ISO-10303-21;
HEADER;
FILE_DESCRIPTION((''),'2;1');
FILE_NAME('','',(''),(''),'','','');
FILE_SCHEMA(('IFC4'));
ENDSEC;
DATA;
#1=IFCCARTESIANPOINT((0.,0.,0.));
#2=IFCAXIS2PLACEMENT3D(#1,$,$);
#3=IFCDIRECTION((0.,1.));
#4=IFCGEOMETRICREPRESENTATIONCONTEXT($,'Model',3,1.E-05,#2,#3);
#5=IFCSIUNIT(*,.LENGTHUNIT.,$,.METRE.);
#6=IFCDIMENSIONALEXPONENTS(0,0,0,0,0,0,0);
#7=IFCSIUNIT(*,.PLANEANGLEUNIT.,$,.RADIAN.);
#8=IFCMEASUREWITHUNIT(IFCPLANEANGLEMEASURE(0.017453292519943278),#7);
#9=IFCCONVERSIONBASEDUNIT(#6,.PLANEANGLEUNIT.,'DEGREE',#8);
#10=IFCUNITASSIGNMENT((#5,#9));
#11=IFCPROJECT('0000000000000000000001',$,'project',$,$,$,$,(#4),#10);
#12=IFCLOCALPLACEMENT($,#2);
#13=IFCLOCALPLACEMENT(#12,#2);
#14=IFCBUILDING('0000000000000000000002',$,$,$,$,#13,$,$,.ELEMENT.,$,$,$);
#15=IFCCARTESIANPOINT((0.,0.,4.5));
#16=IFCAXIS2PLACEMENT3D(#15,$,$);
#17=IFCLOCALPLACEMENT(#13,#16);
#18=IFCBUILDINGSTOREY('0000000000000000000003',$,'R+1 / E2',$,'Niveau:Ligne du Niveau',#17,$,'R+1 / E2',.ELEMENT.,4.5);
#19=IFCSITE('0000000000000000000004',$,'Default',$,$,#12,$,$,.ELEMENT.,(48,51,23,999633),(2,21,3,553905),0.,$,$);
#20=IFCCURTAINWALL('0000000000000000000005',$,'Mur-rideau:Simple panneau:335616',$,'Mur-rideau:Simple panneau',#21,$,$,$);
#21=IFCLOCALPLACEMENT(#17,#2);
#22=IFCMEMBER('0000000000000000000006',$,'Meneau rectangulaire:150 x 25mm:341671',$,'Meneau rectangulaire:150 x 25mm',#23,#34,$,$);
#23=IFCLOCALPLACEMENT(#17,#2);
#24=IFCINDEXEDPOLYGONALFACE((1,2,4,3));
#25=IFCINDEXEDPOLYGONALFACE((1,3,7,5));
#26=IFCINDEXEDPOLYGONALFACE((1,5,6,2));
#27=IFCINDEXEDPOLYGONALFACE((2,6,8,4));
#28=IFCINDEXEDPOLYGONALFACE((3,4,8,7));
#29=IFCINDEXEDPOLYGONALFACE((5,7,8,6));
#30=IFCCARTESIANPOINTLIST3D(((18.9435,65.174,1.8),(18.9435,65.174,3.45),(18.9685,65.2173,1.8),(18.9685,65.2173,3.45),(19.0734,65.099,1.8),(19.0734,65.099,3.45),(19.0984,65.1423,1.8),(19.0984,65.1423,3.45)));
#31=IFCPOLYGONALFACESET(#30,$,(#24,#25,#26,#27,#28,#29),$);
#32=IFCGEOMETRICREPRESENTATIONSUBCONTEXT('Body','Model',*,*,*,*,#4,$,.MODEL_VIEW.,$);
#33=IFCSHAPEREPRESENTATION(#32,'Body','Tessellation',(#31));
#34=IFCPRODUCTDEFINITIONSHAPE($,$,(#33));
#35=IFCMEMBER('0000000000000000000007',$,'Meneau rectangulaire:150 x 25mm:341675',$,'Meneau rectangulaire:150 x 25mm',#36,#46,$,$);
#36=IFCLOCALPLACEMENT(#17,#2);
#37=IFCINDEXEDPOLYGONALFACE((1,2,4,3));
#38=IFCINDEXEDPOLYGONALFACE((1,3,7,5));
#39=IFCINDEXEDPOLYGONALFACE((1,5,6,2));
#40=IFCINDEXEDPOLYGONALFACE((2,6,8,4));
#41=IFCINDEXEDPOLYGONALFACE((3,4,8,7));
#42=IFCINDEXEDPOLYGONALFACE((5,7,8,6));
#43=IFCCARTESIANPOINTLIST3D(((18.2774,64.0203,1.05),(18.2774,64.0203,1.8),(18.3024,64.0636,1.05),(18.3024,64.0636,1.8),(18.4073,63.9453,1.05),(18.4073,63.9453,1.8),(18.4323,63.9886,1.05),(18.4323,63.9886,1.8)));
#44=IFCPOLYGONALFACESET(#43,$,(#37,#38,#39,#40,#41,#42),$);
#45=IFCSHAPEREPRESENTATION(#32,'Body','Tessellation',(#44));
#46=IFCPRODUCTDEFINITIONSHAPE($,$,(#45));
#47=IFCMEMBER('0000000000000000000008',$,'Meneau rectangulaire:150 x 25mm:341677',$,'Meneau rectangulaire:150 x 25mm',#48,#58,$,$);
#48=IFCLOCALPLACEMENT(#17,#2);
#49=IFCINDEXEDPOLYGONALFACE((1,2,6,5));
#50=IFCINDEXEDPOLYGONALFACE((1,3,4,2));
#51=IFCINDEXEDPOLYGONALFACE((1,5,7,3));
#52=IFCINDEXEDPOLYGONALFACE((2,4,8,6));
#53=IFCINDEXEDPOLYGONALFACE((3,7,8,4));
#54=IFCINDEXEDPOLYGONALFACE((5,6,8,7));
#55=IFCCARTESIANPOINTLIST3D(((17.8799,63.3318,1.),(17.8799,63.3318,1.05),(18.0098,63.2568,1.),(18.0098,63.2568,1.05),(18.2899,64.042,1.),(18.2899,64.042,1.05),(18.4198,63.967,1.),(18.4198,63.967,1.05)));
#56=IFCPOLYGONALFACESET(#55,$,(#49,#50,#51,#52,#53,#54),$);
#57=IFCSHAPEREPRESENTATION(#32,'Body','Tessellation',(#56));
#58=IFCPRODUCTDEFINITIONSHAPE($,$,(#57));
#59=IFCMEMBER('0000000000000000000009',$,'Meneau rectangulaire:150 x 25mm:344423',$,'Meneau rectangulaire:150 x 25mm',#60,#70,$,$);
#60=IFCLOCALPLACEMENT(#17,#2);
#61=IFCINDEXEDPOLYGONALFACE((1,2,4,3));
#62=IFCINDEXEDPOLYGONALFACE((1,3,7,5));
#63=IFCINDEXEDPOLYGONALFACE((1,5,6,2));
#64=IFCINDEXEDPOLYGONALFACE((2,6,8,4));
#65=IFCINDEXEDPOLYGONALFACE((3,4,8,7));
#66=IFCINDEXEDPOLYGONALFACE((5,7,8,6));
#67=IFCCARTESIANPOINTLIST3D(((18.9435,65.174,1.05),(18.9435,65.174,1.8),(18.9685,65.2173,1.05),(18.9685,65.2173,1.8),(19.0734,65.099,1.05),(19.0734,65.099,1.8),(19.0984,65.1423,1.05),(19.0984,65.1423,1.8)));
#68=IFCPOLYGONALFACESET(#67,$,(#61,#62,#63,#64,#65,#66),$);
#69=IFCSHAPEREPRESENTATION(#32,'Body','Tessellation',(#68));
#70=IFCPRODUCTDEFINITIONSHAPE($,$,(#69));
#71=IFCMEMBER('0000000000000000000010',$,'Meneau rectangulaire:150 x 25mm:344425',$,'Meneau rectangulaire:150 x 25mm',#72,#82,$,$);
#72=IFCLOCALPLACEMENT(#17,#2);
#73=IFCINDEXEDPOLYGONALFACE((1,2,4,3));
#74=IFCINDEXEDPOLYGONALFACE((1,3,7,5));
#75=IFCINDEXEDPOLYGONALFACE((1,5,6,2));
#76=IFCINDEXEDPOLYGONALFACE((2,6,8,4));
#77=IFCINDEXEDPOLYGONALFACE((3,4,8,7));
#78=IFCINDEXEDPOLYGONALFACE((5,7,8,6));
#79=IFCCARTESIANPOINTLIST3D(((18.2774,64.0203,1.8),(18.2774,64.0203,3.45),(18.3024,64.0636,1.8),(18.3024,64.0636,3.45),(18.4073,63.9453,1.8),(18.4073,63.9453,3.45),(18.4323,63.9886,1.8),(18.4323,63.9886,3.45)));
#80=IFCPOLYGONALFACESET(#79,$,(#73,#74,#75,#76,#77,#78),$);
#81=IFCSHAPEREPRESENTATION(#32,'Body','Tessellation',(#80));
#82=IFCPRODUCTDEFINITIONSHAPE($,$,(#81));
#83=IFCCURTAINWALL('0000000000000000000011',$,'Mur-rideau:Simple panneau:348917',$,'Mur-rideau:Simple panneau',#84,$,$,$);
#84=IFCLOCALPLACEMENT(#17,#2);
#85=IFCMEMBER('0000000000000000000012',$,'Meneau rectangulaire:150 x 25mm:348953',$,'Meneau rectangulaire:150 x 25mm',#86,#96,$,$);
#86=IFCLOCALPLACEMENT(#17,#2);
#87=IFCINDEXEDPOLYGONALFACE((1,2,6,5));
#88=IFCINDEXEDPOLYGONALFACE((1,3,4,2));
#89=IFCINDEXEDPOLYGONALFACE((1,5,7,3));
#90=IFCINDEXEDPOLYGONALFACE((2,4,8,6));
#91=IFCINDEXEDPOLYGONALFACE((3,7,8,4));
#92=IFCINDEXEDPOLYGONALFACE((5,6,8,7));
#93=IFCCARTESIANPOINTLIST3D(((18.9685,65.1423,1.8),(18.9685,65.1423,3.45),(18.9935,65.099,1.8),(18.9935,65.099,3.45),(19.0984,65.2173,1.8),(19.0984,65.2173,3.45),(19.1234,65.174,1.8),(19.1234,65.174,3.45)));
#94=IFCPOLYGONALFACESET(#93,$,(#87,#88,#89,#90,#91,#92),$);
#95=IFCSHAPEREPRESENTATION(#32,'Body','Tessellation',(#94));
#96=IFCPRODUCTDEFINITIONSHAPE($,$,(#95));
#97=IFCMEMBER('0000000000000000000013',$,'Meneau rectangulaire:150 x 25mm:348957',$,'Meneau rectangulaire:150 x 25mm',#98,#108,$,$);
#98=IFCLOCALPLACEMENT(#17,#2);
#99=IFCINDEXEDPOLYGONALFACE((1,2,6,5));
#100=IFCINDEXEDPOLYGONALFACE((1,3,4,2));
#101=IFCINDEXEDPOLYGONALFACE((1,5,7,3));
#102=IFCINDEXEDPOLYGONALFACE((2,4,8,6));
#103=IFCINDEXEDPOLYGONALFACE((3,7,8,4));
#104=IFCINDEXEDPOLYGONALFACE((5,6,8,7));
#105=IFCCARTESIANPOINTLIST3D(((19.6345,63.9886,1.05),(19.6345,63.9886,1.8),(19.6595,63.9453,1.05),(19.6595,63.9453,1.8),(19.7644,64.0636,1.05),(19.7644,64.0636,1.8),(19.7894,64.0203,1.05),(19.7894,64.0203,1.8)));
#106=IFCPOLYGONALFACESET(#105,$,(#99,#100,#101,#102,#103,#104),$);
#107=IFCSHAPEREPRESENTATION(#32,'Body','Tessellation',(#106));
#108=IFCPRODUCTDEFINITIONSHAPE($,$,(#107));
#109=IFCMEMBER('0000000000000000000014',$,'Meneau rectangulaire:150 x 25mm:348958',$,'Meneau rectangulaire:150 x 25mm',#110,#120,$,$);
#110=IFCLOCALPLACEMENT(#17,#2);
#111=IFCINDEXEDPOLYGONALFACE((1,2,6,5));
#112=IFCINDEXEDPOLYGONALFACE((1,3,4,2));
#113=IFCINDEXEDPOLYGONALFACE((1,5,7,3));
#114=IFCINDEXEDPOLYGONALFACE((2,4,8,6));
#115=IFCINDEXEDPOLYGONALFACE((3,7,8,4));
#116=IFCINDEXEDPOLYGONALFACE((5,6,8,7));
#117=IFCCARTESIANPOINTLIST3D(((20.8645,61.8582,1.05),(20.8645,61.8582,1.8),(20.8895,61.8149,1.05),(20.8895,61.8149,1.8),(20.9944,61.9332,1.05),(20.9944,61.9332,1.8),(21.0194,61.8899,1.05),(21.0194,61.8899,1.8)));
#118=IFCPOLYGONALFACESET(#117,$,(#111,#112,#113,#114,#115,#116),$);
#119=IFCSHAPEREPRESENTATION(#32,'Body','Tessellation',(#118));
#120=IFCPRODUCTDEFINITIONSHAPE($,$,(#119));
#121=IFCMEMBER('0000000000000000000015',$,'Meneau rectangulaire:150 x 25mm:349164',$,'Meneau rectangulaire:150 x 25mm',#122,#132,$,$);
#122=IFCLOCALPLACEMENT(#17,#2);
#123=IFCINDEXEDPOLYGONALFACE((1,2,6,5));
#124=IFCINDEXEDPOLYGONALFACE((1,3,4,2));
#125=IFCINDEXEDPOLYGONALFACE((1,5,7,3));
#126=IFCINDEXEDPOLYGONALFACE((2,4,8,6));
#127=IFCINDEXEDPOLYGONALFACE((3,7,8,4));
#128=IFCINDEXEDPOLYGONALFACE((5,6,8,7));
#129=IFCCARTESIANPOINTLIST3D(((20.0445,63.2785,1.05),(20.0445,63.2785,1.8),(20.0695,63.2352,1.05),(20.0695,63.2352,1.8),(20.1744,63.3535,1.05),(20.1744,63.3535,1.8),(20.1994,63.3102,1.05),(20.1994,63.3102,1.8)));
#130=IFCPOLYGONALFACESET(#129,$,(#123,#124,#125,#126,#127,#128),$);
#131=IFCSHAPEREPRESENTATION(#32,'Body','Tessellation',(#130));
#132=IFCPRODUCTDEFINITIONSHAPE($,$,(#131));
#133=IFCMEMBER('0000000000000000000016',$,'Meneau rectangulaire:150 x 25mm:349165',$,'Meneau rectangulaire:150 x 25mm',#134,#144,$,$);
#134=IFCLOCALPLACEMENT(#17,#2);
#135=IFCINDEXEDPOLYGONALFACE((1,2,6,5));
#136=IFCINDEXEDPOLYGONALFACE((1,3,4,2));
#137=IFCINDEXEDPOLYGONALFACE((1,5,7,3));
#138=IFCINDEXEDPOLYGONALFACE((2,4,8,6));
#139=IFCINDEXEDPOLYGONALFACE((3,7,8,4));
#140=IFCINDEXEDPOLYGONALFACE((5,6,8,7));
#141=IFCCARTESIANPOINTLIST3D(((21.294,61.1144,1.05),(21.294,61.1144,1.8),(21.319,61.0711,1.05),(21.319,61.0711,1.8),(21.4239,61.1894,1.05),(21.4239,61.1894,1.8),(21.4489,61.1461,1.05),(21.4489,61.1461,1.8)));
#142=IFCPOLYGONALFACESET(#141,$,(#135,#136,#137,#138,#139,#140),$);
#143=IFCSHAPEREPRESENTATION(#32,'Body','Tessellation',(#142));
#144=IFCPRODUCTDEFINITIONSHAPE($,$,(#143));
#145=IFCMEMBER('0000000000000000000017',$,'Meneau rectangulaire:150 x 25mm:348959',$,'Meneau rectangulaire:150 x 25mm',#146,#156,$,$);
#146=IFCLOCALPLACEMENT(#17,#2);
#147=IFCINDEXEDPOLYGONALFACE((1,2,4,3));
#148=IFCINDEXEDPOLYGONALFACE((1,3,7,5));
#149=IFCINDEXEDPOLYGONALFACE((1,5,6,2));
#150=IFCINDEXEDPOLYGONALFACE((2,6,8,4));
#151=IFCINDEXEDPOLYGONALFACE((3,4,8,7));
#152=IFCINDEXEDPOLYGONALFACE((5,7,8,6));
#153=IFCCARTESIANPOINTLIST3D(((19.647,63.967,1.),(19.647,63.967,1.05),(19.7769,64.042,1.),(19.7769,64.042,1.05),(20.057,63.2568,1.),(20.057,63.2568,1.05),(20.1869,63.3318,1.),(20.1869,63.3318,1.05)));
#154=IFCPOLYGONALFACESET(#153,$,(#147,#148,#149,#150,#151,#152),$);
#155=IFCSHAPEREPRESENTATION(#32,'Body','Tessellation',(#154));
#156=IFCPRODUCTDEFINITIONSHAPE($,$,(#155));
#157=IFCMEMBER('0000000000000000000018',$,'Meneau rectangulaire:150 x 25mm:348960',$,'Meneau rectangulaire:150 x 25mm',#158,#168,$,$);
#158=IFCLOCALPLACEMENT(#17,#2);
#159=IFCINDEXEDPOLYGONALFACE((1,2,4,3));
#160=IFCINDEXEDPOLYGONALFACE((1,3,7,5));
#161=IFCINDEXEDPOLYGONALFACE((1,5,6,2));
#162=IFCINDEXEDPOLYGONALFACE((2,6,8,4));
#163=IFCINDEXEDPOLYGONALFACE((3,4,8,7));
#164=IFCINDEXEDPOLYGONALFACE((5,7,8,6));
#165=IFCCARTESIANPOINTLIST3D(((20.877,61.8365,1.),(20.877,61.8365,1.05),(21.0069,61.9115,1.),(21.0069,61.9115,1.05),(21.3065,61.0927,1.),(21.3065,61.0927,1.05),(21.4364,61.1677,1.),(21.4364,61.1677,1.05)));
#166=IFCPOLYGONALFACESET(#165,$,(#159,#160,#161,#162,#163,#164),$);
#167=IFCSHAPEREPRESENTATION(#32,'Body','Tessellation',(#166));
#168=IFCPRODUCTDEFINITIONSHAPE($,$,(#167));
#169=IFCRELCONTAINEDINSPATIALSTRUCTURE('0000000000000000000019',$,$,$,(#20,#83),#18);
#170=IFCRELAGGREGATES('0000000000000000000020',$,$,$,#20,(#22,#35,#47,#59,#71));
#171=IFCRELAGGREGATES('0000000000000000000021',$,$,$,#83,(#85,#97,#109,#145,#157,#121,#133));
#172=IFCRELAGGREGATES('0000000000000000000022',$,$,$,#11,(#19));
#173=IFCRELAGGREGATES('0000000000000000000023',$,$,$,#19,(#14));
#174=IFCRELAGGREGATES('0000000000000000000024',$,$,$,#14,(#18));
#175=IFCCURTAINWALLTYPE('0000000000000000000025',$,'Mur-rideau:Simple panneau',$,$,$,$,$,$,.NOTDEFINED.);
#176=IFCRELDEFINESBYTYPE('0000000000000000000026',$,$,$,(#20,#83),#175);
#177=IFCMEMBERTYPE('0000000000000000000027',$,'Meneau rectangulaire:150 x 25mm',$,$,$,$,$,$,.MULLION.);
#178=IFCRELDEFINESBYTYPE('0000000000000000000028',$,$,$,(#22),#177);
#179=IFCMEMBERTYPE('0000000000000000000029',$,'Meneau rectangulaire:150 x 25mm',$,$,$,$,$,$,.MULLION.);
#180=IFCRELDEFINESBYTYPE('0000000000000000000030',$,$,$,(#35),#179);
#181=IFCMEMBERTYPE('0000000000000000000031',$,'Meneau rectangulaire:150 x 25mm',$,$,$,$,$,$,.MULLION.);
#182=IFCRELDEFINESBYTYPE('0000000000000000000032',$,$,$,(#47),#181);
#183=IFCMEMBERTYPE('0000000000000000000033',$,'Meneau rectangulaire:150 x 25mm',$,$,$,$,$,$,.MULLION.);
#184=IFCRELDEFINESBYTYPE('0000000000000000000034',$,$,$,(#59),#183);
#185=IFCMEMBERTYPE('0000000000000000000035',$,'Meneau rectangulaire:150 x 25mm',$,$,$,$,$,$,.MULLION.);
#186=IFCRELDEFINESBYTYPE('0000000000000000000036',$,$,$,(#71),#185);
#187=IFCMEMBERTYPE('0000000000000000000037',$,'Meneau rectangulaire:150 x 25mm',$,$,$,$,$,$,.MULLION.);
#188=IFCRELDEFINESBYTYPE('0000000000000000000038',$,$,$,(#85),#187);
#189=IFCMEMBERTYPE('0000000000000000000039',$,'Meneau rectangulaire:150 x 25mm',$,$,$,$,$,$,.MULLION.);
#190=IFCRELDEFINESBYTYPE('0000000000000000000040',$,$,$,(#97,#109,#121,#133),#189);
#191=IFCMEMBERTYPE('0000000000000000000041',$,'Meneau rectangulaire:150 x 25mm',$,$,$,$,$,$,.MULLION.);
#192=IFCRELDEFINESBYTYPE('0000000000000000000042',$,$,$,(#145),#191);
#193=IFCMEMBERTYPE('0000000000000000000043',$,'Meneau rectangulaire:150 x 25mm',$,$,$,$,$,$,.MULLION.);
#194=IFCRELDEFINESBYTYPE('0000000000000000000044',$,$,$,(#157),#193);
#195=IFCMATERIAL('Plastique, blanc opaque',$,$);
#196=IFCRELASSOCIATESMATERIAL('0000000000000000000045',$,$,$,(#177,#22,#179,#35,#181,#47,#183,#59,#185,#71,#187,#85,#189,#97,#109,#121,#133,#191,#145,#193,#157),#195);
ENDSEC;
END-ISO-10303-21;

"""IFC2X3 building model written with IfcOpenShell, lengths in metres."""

from ifc_helpers import new_model, entity, si_unit, converted_unit, direction, frame, origin, origin_2d_with_axis, place, context, subcontext, project, spatial, rectangle, extrude, source, transform, mapped, material, type_object, type_shapes, element, aggregate, save


model = new_model("IFC2X3")

# Units and contexts
model_context = context("Model", 3, precision=1e-05, world=origin(), true_north=direction((0.0, 1.0)))
body_context = subcontext(model_context, "Body", "Model", "MODEL_VIEW")
ifc_project = project(units=[si_unit("LENGTHUNIT", "METRE"), converted_unit("PLANEANGLEUNIT", "DEGREE", entity("IfcPlaneAngleMeasure", 0.017453292519943278), si_unit("PLANEANGLEUNIT", "RADIAN"), dimensions=[0, 0, 0, 0, 0, 0, 0])], contexts=[model_context])

# Site, building, storey
site_placement = place(None, origin())
site = spatial("IfcSite", under=ifc_project, at=site_placement, Name="Default", CompositionType="ELEMENT", RefLatitude=(48, 51, 23, 999633), RefLongitude=(2, 21, 3, 553905), RefElevation=0.0)
building_placement = place(site_placement, origin())
building = spatial("IfcBuilding", under=site, at=building_placement, CompositionType="ELEMENT")
storey_placement = place(building_placement, frame((0.0, 0.0, 4.5)))
storey = spatial("IfcBuildingStorey", under=building, at=storey_placement, Name="R+1 / E2", ObjectType="Niveau:Ligne du Niveau", LongName="R+1 / E2", CompositionType="ELEMENT", Elevation=4.5)

# Curtain walls, members
curtain_wall_type = type_object("IfcCurtainWallType", Name="Mur-rideau:Simple panneau", PredefinedType="NOTDEFINED")
curtain_wall_1_placement = place(storey_placement, frame((0.0, 0.0, -4.5)))
curtain_wall_1 = element("IfcCurtainWall", 1, at=curtain_wall_1_placement, inside=storey, type_object=curtain_wall_type, Name="Mur-rideau:Simple panneau:335616", ObjectType="Mur-rideau:Simple panneau")
ifc_material_1 = material(Name="Plastique, blanc opaque")
member_type_1 = type_object("IfcMemberType", Name="Meneau rectangulaire:150 x 25mm", PredefinedType="MULLION", material=ifc_material_1)
shared_shape_1 = source(origin(), body_context, "Body", "SweptSolid", [
    extrude(rectangle(XDim=0.05, YDim=0.15, at=origin_2d_with_axis()), frame((-0.025, 0.0, -1.65), z_axis=(0.0, 0.0, 1.0), x_axis=(-1.0, 0.0, 0.0)), (0.0, 0.0, 1.0), 1.65),
])
type_shapes(member_type_1, [shared_shape_1])
member_1_placement = place(curtain_wall_1_placement, frame((19.0334, 65.1798, 7.95), z_axis=(0.0, 0.0, 1.0), x_axis=(0.5, 0.866025, 0.0)))
member_1 = element("IfcMember", 2, at=member_1_placement, type_object=member_type_1, material=ifc_material_1, Name="Meneau rectangulaire:150 x 25mm:341671", ObjectType="Meneau rectangulaire:150 x 25mm", context=body_context, shape_type="MappedRepresentation", body=[
    mapped(shared_shape_1, transform((0.0, 0.0, 0.0), scale=1.0)),
])
member_type_2 = type_object("IfcMemberType", Name="Meneau rectangulaire:150 x 25mm", PredefinedType="MULLION", material=ifc_material_1)
shared_shape_2 = source(origin(), body_context, "Body", "SweptSolid", [
    extrude(rectangle(XDim=0.05, YDim=0.15, at=origin_2d_with_axis()), frame((0.0, 0.0, -0.75), z_axis=(0.0, 0.0, 1.0), x_axis=(-1.0, 0.0, 0.0)), (0.0, 0.0, 1.0), 0.75),
])
type_shapes(member_type_2, [shared_shape_2])
member_2_placement = place(curtain_wall_1_placement, frame((18.3549, 64.0045, 5.55), z_axis=(0.0, 0.0, -1.0), x_axis=(-0.5, -0.866025, 0.0)))
member_2 = element("IfcMember", 3, at=member_2_placement, type_object=member_type_2, material=ifc_material_1, Name="Meneau rectangulaire:150 x 25mm:341675", ObjectType="Meneau rectangulaire:150 x 25mm", context=body_context, shape_type="MappedRepresentation", body=[
    mapped(shared_shape_2, transform((0.0, 0.0, 0.0), scale=1.0)),
])
member_type_3 = type_object("IfcMemberType", Name="Meneau rectangulaire:150 x 25mm", PredefinedType="MULLION", material=ifc_material_1)
shared_shape_3 = source(origin(), body_context, "Body", "SweptSolid", [
    extrude(rectangle(XDim=0.05, YDim=0.15, at=origin_2d_with_axis()), frame((-0.025, 0.0, -0.82), z_axis=(0.0, 0.0, 1.0), x_axis=(-1.0, 0.0, 0.0)), (0.0, 0.0, 1.0), 0.82),
])
type_shapes(member_type_3, [shared_shape_3])
member_3_placement = place(curtain_wall_1_placement, frame((18.3549, 64.0045, 5.5), z_axis=(0.5, 0.866025, 0.0), x_axis=(0.0, 0.0, -1.0)))
member_3 = element("IfcMember", 4, at=member_3_placement, type_object=member_type_3, material=ifc_material_1, Name="Meneau rectangulaire:150 x 25mm:341677", ObjectType="Meneau rectangulaire:150 x 25mm", context=body_context, shape_type="MappedRepresentation", body=[
    mapped(shared_shape_3, transform((0.0, 0.0, 0.0), scale=1.0)),
])
member_type_4 = type_object("IfcMemberType", Name="Meneau rectangulaire:150 x 25mm", PredefinedType="MULLION", material=ifc_material_1)
shared_shape_4 = source(origin(), body_context, "Body", "SweptSolid", [
    extrude(rectangle(XDim=0.05, YDim=0.15, at=origin_2d_with_axis()), frame((-0.025, 0.0, -0.75), z_axis=(0.0, 0.0, 1.0), x_axis=(-1.0, 0.0, 0.0)), (0.0, 0.0, 1.0), 0.75),
])
type_shapes(member_type_4, [shared_shape_4])
member_4_placement = place(curtain_wall_1_placement, frame((19.0334, 65.1798, 6.3), z_axis=(0.0, 0.0, 1.0), x_axis=(0.5, 0.866025, 0.0)))
member_4 = element("IfcMember", 5, at=member_4_placement, type_object=member_type_4, material=ifc_material_1, Name="Meneau rectangulaire:150 x 25mm:344423", ObjectType="Meneau rectangulaire:150 x 25mm", context=body_context, shape_type="MappedRepresentation", body=[
    mapped(shared_shape_4, transform((0.0, 0.0, 0.0), scale=1.0)),
])
member_type_5 = type_object("IfcMemberType", Name="Meneau rectangulaire:150 x 25mm", PredefinedType="MULLION", material=ifc_material_1)
shared_shape_5 = source(origin(), body_context, "Body", "SweptSolid", [
    extrude(rectangle(XDim=0.05, YDim=0.15, at=origin_2d_with_axis()), frame((0.0, 0.0, -1.65), z_axis=(0.0, 0.0, 1.0), x_axis=(-1.0, 0.0, 0.0)), (0.0, 0.0, 1.0), 1.65),
])
type_shapes(member_type_5, [shared_shape_5])
member_5_placement = place(curtain_wall_1_placement, frame((18.3549, 64.0045, 6.3), z_axis=(0.0, 0.0, -1.0), x_axis=(-0.5, -0.866025, 0.0)))
member_5 = element("IfcMember", 6, at=member_5_placement, type_object=member_type_5, material=ifc_material_1, Name="Meneau rectangulaire:150 x 25mm:344425", ObjectType="Meneau rectangulaire:150 x 25mm", context=body_context, shape_type="MappedRepresentation", body=[
    mapped(shared_shape_5, transform((0.0, 0.0, 0.0), scale=1.0)),
])
curtain_wall_2_placement = place(storey_placement, frame((0.0, 0.0, -4.5)))
curtain_wall_2 = element("IfcCurtainWall", 7, at=curtain_wall_2_placement, inside=storey, type_object=curtain_wall_type, Name="Mur-rideau:Simple panneau:348917", ObjectType="Mur-rideau:Simple panneau")
member_type_6 = type_object("IfcMemberType", Name="Meneau rectangulaire:150 x 25mm", PredefinedType="MULLION", material=ifc_material_1)
shared_shape_6 = source(origin(), body_context, "Body", "SweptSolid", [
    extrude(rectangle(XDim=0.05, YDim=0.15, at=origin_2d_with_axis()), frame((-0.025, 0.0, -1.65), z_axis=(0.0, 0.0, 1.0), x_axis=(-1.0, 0.0, 0.0)), (0.0, 0.0, 1.0), 1.65),
])
type_shapes(member_type_6, [shared_shape_6])
member_6_placement = place(curtain_wall_2_placement, frame((19.0334, 65.1798, 7.95), z_axis=(0.0, 0.0, 1.0), x_axis=(-0.5, 0.866025, 0.0)))
member_6 = element("IfcMember", 8, at=member_6_placement, type_object=member_type_6, material=ifc_material_1, Name="Meneau rectangulaire:150 x 25mm:348953", ObjectType="Meneau rectangulaire:150 x 25mm", context=body_context, shape_type="MappedRepresentation", body=[
    mapped(shared_shape_6, transform((0.0, 0.0, 0.0), scale=1.0)),
])
member_type_7 = type_object("IfcMemberType", Name="Meneau rectangulaire:150 x 25mm", PredefinedType="MULLION", material=ifc_material_1)
shared_shape_7 = source(origin(), body_context, "Body", "SweptSolid", [
    extrude(rectangle(XDim=0.05, YDim=0.15, at=origin_2d_with_axis()), frame((0.0, 0.0, -0.75), z_axis=(0.0, 0.0, 1.0), x_axis=(-1.0, 0.0, 0.0)), (0.0, 0.0, 1.0), 0.75),
])
type_shapes(member_type_7, [shared_shape_7])
member_7_placement = place(curtain_wall_2_placement, frame((19.712, 64.0045, 5.55), z_axis=(0.0, 0.0, -1.0), x_axis=(0.5, -0.866025, 0.0)))
member_7 = element("IfcMember", 9, at=member_7_placement, type_object=member_type_7, material=ifc_material_1, Name="Meneau rectangulaire:150 x 25mm:348957", ObjectType="Meneau rectangulaire:150 x 25mm", context=body_context, shape_type="MappedRepresentation", body=[
    mapped(shared_shape_7, transform((0.0, 0.0, 0.0), scale=1.0)),
])
member_8_placement = place(curtain_wall_2_placement, frame((20.942, 61.874, 5.55), z_axis=(0.0, 0.0, -1.0), x_axis=(0.5, -0.866025, 0.0)))
member_8 = element("IfcMember", 10, at=member_8_placement, type_object=member_type_7, material=ifc_material_1, Name="Meneau rectangulaire:150 x 25mm:348958", ObjectType="Meneau rectangulaire:150 x 25mm", context=body_context, shape_type="MappedRepresentation", body=[
    mapped(shared_shape_7, transform((0.0, 0.0, 0.0), scale=1.0)),
])
member_9_placement = place(curtain_wall_2_placement, frame((20.122, 63.2943, 5.55), z_axis=(0.0, 0.0, -1.0), x_axis=(0.5, -0.866025, 0.0)))
member_9 = element("IfcMember", 11, at=member_9_placement, type_object=member_type_7, material=ifc_material_1, Name="Meneau rectangulaire:150 x 25mm:349164", ObjectType="Meneau rectangulaire:150 x 25mm", context=body_context, shape_type="MappedRepresentation", body=[
    mapped(shared_shape_7, transform((0.0, 0.0, 0.0), scale=1.0)),
])
member_10_placement = place(curtain_wall_2_placement, frame((21.3714, 61.1302, 5.55), z_axis=(0.0, 0.0, -1.0), x_axis=(0.5, -0.866025, 0.0)))
member_10 = element("IfcMember", 12, at=member_10_placement, type_object=member_type_7, material=ifc_material_1, Name="Meneau rectangulaire:150 x 25mm:349165", ObjectType="Meneau rectangulaire:150 x 25mm", context=body_context, shape_type="MappedRepresentation", body=[
    mapped(shared_shape_7, transform((0.0, 0.0, 0.0), scale=1.0)),
])
member_type_8 = type_object("IfcMemberType", Name="Meneau rectangulaire:150 x 25mm", PredefinedType="MULLION", material=ifc_material_1)
shared_shape_8 = source(origin(), body_context, "Body", "SweptSolid", [
    extrude(rectangle(XDim=0.05, YDim=0.15, at=origin_2d_with_axis()), frame((-0.025, 0.0, -0.82), z_axis=(0.0, 0.0, 1.0), x_axis=(-1.0, 0.0, 0.0)), (0.0, 0.0, 1.0), 0.82),
])
type_shapes(member_type_8, [shared_shape_8])
member_11_placement = place(curtain_wall_2_placement, frame((19.712, 64.0045, 5.5), z_axis=(-0.5, 0.866025, 0.0), x_axis=(0.0, 0.0, -1.0)))
member_11 = element("IfcMember", 13, at=member_11_placement, type_object=member_type_8, material=ifc_material_1, Name="Meneau rectangulaire:150 x 25mm:348959", ObjectType="Meneau rectangulaire:150 x 25mm", context=body_context, shape_type="MappedRepresentation", body=[
    mapped(shared_shape_8, transform((0.0, 0.0, 0.0), scale=1.0)),
])
member_type_9 = type_object("IfcMemberType", Name="Meneau rectangulaire:150 x 25mm", PredefinedType="MULLION", material=ifc_material_1)
shared_shape_9 = source(origin(), body_context, "Body", "SweptSolid", [
    extrude(rectangle(XDim=0.05, YDim=0.15, at=origin_2d_with_axis()), frame((-0.025, 0.0, -0.8589), z_axis=(0.0, 0.0, 1.0), x_axis=(-1.0, 0.0, 0.0)), (0.0, 0.0, 1.0), 0.8589),
])
type_shapes(member_type_9, [shared_shape_9])
member_12_placement = place(curtain_wall_2_placement, frame((20.942, 61.874, 5.5), z_axis=(-0.5, 0.866025, 0.0), x_axis=(0.0, 0.0, -1.0)))
member_12 = element("IfcMember", 14, at=member_12_placement, type_object=member_type_9, material=ifc_material_1, Name="Meneau rectangulaire:150 x 25mm:348960", ObjectType="Meneau rectangulaire:150 x 25mm", context=body_context, shape_type="MappedRepresentation", body=[
    mapped(shared_shape_9, transform((0.0, 0.0, 0.0), scale=1.0)),
])

aggregate(curtain_wall_1, [member_1, member_2, member_3, member_4, member_5])
aggregate(curtain_wall_2, [member_6, member_7, member_8, member_11, member_12, member_9, member_10])

save(model, "model.ifc")
